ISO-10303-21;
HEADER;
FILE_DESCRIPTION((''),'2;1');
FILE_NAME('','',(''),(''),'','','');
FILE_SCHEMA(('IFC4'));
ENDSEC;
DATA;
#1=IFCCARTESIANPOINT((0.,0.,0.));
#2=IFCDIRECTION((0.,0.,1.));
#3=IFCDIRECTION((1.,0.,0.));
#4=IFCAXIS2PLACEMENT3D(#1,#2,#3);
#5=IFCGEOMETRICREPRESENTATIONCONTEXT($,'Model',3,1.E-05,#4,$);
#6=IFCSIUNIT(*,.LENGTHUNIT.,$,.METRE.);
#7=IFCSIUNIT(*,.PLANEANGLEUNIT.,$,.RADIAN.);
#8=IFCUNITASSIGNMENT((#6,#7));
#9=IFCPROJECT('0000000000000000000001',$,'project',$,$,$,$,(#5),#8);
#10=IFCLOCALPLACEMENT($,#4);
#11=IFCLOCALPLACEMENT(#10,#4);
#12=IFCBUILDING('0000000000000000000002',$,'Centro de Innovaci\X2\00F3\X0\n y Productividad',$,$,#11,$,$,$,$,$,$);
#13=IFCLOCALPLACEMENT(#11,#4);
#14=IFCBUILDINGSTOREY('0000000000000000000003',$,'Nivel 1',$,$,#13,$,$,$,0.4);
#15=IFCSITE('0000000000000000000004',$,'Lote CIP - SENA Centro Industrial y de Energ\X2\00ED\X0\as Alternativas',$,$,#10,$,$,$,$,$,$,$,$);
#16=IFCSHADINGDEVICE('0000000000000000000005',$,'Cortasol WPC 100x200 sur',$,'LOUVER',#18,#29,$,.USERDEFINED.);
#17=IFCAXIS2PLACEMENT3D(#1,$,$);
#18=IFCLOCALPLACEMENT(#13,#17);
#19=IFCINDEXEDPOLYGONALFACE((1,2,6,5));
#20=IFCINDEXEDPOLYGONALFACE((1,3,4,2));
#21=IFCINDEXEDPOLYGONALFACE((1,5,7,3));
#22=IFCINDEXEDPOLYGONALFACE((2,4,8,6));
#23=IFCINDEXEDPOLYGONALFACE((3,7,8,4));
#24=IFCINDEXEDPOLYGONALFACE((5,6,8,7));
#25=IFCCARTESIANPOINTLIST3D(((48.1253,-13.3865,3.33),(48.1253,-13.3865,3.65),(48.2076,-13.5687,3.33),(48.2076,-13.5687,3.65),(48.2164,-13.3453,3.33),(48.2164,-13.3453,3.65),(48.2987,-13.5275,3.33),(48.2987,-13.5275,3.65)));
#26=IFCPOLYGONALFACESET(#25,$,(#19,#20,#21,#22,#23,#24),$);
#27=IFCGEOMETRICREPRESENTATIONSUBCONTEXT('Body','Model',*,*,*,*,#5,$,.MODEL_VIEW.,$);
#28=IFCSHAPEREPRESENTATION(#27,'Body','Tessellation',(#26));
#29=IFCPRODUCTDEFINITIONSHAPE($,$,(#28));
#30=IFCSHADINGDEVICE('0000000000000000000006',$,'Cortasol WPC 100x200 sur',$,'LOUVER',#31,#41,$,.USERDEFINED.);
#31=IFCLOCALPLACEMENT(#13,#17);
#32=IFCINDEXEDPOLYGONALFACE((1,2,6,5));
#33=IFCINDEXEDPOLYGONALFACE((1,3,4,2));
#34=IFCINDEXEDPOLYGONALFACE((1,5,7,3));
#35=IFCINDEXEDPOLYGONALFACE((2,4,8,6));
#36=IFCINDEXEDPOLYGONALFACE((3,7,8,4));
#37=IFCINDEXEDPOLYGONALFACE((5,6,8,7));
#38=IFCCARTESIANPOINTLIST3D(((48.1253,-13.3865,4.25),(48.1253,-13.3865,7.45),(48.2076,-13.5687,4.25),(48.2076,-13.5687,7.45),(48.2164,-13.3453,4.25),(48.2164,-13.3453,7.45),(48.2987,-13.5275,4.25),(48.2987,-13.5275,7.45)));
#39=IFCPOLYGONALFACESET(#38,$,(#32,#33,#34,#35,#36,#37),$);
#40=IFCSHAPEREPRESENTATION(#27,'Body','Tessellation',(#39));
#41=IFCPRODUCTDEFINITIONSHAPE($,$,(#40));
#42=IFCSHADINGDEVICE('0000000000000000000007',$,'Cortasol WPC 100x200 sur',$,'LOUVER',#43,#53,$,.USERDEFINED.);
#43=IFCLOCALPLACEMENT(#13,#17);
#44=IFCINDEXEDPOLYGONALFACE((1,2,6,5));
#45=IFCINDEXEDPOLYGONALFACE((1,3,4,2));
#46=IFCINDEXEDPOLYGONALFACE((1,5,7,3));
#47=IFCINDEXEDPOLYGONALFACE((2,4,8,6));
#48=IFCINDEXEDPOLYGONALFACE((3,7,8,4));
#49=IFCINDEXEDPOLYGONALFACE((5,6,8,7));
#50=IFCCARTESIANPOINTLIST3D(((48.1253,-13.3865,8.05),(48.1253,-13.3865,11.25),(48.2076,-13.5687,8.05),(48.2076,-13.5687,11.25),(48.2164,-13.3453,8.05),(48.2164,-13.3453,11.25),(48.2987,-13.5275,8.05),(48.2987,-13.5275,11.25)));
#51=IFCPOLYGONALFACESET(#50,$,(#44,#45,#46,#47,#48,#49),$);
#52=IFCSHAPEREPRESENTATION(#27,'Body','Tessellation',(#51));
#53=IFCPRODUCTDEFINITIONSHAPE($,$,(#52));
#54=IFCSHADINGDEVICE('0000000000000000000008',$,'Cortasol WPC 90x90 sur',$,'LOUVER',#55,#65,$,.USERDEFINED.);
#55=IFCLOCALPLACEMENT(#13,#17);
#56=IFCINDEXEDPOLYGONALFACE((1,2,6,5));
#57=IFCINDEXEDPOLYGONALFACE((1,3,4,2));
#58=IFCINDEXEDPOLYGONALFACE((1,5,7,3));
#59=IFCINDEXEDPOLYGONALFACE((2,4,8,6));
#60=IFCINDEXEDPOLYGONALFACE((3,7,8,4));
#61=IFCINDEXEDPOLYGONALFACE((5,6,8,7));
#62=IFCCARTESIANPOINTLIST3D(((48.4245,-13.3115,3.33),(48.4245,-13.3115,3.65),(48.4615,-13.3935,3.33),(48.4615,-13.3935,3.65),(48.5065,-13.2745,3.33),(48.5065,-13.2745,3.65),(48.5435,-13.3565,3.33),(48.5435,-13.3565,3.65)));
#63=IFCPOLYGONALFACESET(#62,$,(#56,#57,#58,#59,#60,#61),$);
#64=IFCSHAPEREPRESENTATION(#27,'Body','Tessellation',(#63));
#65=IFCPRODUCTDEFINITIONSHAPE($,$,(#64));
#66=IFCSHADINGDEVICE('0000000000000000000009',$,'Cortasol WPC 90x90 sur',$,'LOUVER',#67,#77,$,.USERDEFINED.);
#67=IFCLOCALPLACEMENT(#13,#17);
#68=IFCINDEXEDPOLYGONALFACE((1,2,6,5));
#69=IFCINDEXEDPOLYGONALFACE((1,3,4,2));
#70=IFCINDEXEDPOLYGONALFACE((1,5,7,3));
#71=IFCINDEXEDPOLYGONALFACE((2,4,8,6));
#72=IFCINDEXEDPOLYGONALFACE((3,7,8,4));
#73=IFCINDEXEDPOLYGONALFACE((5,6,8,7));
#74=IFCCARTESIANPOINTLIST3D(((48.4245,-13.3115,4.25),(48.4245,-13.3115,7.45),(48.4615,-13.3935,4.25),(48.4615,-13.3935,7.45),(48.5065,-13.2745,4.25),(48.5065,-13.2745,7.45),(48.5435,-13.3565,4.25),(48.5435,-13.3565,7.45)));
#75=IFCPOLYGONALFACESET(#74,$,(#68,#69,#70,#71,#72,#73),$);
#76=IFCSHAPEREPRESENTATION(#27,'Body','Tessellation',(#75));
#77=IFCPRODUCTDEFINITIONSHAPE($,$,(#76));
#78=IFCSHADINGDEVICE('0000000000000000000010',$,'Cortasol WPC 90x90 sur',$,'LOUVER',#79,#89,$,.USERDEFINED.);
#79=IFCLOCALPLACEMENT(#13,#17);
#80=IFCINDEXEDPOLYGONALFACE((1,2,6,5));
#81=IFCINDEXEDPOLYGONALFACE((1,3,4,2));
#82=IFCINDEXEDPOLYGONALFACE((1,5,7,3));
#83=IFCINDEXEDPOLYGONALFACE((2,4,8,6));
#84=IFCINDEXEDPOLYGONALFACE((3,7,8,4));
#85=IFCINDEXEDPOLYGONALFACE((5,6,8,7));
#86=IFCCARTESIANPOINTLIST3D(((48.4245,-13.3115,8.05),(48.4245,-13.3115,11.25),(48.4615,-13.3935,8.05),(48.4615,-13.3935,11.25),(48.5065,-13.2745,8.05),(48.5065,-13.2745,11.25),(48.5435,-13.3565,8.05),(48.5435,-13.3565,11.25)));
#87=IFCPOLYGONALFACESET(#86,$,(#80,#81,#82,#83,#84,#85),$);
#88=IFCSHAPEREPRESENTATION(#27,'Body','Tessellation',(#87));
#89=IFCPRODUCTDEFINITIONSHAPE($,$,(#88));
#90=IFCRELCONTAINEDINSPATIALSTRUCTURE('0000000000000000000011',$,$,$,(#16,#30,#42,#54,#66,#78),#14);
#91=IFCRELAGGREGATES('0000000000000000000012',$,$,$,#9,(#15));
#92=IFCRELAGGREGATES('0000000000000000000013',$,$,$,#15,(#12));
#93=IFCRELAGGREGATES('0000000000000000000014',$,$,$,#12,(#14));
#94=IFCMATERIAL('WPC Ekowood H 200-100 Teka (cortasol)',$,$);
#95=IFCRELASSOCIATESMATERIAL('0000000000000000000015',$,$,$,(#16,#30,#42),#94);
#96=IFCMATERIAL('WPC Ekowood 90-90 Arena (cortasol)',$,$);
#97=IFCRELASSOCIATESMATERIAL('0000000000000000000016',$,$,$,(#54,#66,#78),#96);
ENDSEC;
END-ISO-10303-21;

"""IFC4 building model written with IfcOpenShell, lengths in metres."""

from ifc_helpers import new_model, si_unit, frame, origin_with_axes, place, context, subcontext, project, spatial, polyline, outline, extrude, material, element, save


model = new_model("IFC4")

# Units and contexts
model_context = context("Model", 3, precision=1e-05, world=origin_with_axes())
body_context = subcontext(model_context, "Body", "Model", "MODEL_VIEW")
ifc_project = project(units=[si_unit("LENGTHUNIT", "METRE"), si_unit("PLANEANGLEUNIT", "RADIAN")], contexts=[model_context])

# Site, building, storey
site_placement = place(None, origin_with_axes())
site = spatial("IfcSite", under=ifc_project, at=site_placement, Name="Lote CIP - SENA Centro Industrial y de Energías Alternativas")
building_placement = place(site_placement, origin_with_axes())
building = spatial("IfcBuilding", under=site, at=building_placement, Name="Centro de Innovación y Productividad")
storey_placement = place(building_placement, origin_with_axes())
storey = spatial("IfcBuildingStorey", under=building, at=storey_placement, Name="Nivel 1", Elevation=0.4)

# Shading devices
ifc_material_1 = material(Name="WPC Ekowood 90-90 Arena (cortasol)")
ifc_material_2 = material(Name="WPC Ekowood H 200-100 Teka (cortasol)")
shading_device_1_placement = place(storey_placement, origin_with_axes())
element("IfcShadingDevice", 1, at=shading_device_1_placement, inside=storey, material=ifc_material_2, Name="Cortasol WPC 100x200 sur", ObjectType="LOUVER", PredefinedType="USERDEFINED", context=body_context, shape_type="SweptSolid", body=[
    extrude(outline(polyline([(48.2076, -13.5687), (48.1253, -13.3865), (48.2164, -13.3453), (48.2987, -13.5275), (48.2076, -13.5687)])), frame((0.0, 0.0, 3.33)), (0.0, 0.0, 1.0), 0.32),
])
shading_device_2_placement = place(storey_placement, origin_with_axes())
element("IfcShadingDevice", 2, at=shading_device_2_placement, inside=storey, material=ifc_material_2, Name="Cortasol WPC 100x200 sur", ObjectType="LOUVER", PredefinedType="USERDEFINED", context=body_context, shape_type="SweptSolid", body=[
    extrude(outline(polyline([(48.2076, -13.5687), (48.1253, -13.3865), (48.2164, -13.3453), (48.2987, -13.5275), (48.2076, -13.5687)])), frame((0.0, 0.0, 4.25)), (0.0, 0.0, 1.0), 3.2),
])
shading_device_3_placement = place(storey_placement, origin_with_axes())
element("IfcShadingDevice", 3, at=shading_device_3_placement, inside=storey, material=ifc_material_2, Name="Cortasol WPC 100x200 sur", ObjectType="LOUVER", PredefinedType="USERDEFINED", context=body_context, shape_type="SweptSolid", body=[
    extrude(outline(polyline([(48.2076, -13.5687), (48.1253, -13.3865), (48.2164, -13.3453), (48.2987, -13.5275), (48.2076, -13.5687)])), frame((0.0, 0.0, 8.05)), (0.0, 0.0, 1.0), 3.2),
])
shading_device_4_placement = place(storey_placement, origin_with_axes())
element("IfcShadingDevice", 4, at=shading_device_4_placement, inside=storey, material=ifc_material_1, Name="Cortasol WPC 90x90 sur", ObjectType="LOUVER", PredefinedType="USERDEFINED", context=body_context, shape_type="SweptSolid", body=[
    extrude(outline(polyline([(48.4615, -13.3935), (48.4245, -13.3115), (48.5065, -13.2745), (48.5435, -13.3565), (48.4615, -13.3935)])), frame((0.0, 0.0, 3.33)), (0.0, 0.0, 1.0), 0.32),
])
shading_device_5_placement = place(storey_placement, origin_with_axes())
element("IfcShadingDevice", 5, at=shading_device_5_placement, inside=storey, material=ifc_material_1, Name="Cortasol WPC 90x90 sur", ObjectType="LOUVER", PredefinedType="USERDEFINED", context=body_context, shape_type="SweptSolid", body=[
    extrude(outline(polyline([(48.4615, -13.3935), (48.4245, -13.3115), (48.5065, -13.2745), (48.5435, -13.3565), (48.4615, -13.3935)])), frame((0.0, 0.0, 4.25)), (0.0, 0.0, 1.0), 3.2),
])
shading_device_6_placement = place(storey_placement, origin_with_axes())
element("IfcShadingDevice", 6, at=shading_device_6_placement, inside=storey, material=ifc_material_1, Name="Cortasol WPC 90x90 sur", ObjectType="LOUVER", PredefinedType="USERDEFINED", context=body_context, shape_type="SweptSolid", body=[
    extrude(outline(polyline([(48.4615, -13.3935), (48.4245, -13.3115), (48.5065, -13.2745), (48.5435, -13.3565), (48.4615, -13.3935)])), frame((0.0, 0.0, 8.05)), (0.0, 0.0, 1.0), 3.2),
])

save(model, "model.ifc")
